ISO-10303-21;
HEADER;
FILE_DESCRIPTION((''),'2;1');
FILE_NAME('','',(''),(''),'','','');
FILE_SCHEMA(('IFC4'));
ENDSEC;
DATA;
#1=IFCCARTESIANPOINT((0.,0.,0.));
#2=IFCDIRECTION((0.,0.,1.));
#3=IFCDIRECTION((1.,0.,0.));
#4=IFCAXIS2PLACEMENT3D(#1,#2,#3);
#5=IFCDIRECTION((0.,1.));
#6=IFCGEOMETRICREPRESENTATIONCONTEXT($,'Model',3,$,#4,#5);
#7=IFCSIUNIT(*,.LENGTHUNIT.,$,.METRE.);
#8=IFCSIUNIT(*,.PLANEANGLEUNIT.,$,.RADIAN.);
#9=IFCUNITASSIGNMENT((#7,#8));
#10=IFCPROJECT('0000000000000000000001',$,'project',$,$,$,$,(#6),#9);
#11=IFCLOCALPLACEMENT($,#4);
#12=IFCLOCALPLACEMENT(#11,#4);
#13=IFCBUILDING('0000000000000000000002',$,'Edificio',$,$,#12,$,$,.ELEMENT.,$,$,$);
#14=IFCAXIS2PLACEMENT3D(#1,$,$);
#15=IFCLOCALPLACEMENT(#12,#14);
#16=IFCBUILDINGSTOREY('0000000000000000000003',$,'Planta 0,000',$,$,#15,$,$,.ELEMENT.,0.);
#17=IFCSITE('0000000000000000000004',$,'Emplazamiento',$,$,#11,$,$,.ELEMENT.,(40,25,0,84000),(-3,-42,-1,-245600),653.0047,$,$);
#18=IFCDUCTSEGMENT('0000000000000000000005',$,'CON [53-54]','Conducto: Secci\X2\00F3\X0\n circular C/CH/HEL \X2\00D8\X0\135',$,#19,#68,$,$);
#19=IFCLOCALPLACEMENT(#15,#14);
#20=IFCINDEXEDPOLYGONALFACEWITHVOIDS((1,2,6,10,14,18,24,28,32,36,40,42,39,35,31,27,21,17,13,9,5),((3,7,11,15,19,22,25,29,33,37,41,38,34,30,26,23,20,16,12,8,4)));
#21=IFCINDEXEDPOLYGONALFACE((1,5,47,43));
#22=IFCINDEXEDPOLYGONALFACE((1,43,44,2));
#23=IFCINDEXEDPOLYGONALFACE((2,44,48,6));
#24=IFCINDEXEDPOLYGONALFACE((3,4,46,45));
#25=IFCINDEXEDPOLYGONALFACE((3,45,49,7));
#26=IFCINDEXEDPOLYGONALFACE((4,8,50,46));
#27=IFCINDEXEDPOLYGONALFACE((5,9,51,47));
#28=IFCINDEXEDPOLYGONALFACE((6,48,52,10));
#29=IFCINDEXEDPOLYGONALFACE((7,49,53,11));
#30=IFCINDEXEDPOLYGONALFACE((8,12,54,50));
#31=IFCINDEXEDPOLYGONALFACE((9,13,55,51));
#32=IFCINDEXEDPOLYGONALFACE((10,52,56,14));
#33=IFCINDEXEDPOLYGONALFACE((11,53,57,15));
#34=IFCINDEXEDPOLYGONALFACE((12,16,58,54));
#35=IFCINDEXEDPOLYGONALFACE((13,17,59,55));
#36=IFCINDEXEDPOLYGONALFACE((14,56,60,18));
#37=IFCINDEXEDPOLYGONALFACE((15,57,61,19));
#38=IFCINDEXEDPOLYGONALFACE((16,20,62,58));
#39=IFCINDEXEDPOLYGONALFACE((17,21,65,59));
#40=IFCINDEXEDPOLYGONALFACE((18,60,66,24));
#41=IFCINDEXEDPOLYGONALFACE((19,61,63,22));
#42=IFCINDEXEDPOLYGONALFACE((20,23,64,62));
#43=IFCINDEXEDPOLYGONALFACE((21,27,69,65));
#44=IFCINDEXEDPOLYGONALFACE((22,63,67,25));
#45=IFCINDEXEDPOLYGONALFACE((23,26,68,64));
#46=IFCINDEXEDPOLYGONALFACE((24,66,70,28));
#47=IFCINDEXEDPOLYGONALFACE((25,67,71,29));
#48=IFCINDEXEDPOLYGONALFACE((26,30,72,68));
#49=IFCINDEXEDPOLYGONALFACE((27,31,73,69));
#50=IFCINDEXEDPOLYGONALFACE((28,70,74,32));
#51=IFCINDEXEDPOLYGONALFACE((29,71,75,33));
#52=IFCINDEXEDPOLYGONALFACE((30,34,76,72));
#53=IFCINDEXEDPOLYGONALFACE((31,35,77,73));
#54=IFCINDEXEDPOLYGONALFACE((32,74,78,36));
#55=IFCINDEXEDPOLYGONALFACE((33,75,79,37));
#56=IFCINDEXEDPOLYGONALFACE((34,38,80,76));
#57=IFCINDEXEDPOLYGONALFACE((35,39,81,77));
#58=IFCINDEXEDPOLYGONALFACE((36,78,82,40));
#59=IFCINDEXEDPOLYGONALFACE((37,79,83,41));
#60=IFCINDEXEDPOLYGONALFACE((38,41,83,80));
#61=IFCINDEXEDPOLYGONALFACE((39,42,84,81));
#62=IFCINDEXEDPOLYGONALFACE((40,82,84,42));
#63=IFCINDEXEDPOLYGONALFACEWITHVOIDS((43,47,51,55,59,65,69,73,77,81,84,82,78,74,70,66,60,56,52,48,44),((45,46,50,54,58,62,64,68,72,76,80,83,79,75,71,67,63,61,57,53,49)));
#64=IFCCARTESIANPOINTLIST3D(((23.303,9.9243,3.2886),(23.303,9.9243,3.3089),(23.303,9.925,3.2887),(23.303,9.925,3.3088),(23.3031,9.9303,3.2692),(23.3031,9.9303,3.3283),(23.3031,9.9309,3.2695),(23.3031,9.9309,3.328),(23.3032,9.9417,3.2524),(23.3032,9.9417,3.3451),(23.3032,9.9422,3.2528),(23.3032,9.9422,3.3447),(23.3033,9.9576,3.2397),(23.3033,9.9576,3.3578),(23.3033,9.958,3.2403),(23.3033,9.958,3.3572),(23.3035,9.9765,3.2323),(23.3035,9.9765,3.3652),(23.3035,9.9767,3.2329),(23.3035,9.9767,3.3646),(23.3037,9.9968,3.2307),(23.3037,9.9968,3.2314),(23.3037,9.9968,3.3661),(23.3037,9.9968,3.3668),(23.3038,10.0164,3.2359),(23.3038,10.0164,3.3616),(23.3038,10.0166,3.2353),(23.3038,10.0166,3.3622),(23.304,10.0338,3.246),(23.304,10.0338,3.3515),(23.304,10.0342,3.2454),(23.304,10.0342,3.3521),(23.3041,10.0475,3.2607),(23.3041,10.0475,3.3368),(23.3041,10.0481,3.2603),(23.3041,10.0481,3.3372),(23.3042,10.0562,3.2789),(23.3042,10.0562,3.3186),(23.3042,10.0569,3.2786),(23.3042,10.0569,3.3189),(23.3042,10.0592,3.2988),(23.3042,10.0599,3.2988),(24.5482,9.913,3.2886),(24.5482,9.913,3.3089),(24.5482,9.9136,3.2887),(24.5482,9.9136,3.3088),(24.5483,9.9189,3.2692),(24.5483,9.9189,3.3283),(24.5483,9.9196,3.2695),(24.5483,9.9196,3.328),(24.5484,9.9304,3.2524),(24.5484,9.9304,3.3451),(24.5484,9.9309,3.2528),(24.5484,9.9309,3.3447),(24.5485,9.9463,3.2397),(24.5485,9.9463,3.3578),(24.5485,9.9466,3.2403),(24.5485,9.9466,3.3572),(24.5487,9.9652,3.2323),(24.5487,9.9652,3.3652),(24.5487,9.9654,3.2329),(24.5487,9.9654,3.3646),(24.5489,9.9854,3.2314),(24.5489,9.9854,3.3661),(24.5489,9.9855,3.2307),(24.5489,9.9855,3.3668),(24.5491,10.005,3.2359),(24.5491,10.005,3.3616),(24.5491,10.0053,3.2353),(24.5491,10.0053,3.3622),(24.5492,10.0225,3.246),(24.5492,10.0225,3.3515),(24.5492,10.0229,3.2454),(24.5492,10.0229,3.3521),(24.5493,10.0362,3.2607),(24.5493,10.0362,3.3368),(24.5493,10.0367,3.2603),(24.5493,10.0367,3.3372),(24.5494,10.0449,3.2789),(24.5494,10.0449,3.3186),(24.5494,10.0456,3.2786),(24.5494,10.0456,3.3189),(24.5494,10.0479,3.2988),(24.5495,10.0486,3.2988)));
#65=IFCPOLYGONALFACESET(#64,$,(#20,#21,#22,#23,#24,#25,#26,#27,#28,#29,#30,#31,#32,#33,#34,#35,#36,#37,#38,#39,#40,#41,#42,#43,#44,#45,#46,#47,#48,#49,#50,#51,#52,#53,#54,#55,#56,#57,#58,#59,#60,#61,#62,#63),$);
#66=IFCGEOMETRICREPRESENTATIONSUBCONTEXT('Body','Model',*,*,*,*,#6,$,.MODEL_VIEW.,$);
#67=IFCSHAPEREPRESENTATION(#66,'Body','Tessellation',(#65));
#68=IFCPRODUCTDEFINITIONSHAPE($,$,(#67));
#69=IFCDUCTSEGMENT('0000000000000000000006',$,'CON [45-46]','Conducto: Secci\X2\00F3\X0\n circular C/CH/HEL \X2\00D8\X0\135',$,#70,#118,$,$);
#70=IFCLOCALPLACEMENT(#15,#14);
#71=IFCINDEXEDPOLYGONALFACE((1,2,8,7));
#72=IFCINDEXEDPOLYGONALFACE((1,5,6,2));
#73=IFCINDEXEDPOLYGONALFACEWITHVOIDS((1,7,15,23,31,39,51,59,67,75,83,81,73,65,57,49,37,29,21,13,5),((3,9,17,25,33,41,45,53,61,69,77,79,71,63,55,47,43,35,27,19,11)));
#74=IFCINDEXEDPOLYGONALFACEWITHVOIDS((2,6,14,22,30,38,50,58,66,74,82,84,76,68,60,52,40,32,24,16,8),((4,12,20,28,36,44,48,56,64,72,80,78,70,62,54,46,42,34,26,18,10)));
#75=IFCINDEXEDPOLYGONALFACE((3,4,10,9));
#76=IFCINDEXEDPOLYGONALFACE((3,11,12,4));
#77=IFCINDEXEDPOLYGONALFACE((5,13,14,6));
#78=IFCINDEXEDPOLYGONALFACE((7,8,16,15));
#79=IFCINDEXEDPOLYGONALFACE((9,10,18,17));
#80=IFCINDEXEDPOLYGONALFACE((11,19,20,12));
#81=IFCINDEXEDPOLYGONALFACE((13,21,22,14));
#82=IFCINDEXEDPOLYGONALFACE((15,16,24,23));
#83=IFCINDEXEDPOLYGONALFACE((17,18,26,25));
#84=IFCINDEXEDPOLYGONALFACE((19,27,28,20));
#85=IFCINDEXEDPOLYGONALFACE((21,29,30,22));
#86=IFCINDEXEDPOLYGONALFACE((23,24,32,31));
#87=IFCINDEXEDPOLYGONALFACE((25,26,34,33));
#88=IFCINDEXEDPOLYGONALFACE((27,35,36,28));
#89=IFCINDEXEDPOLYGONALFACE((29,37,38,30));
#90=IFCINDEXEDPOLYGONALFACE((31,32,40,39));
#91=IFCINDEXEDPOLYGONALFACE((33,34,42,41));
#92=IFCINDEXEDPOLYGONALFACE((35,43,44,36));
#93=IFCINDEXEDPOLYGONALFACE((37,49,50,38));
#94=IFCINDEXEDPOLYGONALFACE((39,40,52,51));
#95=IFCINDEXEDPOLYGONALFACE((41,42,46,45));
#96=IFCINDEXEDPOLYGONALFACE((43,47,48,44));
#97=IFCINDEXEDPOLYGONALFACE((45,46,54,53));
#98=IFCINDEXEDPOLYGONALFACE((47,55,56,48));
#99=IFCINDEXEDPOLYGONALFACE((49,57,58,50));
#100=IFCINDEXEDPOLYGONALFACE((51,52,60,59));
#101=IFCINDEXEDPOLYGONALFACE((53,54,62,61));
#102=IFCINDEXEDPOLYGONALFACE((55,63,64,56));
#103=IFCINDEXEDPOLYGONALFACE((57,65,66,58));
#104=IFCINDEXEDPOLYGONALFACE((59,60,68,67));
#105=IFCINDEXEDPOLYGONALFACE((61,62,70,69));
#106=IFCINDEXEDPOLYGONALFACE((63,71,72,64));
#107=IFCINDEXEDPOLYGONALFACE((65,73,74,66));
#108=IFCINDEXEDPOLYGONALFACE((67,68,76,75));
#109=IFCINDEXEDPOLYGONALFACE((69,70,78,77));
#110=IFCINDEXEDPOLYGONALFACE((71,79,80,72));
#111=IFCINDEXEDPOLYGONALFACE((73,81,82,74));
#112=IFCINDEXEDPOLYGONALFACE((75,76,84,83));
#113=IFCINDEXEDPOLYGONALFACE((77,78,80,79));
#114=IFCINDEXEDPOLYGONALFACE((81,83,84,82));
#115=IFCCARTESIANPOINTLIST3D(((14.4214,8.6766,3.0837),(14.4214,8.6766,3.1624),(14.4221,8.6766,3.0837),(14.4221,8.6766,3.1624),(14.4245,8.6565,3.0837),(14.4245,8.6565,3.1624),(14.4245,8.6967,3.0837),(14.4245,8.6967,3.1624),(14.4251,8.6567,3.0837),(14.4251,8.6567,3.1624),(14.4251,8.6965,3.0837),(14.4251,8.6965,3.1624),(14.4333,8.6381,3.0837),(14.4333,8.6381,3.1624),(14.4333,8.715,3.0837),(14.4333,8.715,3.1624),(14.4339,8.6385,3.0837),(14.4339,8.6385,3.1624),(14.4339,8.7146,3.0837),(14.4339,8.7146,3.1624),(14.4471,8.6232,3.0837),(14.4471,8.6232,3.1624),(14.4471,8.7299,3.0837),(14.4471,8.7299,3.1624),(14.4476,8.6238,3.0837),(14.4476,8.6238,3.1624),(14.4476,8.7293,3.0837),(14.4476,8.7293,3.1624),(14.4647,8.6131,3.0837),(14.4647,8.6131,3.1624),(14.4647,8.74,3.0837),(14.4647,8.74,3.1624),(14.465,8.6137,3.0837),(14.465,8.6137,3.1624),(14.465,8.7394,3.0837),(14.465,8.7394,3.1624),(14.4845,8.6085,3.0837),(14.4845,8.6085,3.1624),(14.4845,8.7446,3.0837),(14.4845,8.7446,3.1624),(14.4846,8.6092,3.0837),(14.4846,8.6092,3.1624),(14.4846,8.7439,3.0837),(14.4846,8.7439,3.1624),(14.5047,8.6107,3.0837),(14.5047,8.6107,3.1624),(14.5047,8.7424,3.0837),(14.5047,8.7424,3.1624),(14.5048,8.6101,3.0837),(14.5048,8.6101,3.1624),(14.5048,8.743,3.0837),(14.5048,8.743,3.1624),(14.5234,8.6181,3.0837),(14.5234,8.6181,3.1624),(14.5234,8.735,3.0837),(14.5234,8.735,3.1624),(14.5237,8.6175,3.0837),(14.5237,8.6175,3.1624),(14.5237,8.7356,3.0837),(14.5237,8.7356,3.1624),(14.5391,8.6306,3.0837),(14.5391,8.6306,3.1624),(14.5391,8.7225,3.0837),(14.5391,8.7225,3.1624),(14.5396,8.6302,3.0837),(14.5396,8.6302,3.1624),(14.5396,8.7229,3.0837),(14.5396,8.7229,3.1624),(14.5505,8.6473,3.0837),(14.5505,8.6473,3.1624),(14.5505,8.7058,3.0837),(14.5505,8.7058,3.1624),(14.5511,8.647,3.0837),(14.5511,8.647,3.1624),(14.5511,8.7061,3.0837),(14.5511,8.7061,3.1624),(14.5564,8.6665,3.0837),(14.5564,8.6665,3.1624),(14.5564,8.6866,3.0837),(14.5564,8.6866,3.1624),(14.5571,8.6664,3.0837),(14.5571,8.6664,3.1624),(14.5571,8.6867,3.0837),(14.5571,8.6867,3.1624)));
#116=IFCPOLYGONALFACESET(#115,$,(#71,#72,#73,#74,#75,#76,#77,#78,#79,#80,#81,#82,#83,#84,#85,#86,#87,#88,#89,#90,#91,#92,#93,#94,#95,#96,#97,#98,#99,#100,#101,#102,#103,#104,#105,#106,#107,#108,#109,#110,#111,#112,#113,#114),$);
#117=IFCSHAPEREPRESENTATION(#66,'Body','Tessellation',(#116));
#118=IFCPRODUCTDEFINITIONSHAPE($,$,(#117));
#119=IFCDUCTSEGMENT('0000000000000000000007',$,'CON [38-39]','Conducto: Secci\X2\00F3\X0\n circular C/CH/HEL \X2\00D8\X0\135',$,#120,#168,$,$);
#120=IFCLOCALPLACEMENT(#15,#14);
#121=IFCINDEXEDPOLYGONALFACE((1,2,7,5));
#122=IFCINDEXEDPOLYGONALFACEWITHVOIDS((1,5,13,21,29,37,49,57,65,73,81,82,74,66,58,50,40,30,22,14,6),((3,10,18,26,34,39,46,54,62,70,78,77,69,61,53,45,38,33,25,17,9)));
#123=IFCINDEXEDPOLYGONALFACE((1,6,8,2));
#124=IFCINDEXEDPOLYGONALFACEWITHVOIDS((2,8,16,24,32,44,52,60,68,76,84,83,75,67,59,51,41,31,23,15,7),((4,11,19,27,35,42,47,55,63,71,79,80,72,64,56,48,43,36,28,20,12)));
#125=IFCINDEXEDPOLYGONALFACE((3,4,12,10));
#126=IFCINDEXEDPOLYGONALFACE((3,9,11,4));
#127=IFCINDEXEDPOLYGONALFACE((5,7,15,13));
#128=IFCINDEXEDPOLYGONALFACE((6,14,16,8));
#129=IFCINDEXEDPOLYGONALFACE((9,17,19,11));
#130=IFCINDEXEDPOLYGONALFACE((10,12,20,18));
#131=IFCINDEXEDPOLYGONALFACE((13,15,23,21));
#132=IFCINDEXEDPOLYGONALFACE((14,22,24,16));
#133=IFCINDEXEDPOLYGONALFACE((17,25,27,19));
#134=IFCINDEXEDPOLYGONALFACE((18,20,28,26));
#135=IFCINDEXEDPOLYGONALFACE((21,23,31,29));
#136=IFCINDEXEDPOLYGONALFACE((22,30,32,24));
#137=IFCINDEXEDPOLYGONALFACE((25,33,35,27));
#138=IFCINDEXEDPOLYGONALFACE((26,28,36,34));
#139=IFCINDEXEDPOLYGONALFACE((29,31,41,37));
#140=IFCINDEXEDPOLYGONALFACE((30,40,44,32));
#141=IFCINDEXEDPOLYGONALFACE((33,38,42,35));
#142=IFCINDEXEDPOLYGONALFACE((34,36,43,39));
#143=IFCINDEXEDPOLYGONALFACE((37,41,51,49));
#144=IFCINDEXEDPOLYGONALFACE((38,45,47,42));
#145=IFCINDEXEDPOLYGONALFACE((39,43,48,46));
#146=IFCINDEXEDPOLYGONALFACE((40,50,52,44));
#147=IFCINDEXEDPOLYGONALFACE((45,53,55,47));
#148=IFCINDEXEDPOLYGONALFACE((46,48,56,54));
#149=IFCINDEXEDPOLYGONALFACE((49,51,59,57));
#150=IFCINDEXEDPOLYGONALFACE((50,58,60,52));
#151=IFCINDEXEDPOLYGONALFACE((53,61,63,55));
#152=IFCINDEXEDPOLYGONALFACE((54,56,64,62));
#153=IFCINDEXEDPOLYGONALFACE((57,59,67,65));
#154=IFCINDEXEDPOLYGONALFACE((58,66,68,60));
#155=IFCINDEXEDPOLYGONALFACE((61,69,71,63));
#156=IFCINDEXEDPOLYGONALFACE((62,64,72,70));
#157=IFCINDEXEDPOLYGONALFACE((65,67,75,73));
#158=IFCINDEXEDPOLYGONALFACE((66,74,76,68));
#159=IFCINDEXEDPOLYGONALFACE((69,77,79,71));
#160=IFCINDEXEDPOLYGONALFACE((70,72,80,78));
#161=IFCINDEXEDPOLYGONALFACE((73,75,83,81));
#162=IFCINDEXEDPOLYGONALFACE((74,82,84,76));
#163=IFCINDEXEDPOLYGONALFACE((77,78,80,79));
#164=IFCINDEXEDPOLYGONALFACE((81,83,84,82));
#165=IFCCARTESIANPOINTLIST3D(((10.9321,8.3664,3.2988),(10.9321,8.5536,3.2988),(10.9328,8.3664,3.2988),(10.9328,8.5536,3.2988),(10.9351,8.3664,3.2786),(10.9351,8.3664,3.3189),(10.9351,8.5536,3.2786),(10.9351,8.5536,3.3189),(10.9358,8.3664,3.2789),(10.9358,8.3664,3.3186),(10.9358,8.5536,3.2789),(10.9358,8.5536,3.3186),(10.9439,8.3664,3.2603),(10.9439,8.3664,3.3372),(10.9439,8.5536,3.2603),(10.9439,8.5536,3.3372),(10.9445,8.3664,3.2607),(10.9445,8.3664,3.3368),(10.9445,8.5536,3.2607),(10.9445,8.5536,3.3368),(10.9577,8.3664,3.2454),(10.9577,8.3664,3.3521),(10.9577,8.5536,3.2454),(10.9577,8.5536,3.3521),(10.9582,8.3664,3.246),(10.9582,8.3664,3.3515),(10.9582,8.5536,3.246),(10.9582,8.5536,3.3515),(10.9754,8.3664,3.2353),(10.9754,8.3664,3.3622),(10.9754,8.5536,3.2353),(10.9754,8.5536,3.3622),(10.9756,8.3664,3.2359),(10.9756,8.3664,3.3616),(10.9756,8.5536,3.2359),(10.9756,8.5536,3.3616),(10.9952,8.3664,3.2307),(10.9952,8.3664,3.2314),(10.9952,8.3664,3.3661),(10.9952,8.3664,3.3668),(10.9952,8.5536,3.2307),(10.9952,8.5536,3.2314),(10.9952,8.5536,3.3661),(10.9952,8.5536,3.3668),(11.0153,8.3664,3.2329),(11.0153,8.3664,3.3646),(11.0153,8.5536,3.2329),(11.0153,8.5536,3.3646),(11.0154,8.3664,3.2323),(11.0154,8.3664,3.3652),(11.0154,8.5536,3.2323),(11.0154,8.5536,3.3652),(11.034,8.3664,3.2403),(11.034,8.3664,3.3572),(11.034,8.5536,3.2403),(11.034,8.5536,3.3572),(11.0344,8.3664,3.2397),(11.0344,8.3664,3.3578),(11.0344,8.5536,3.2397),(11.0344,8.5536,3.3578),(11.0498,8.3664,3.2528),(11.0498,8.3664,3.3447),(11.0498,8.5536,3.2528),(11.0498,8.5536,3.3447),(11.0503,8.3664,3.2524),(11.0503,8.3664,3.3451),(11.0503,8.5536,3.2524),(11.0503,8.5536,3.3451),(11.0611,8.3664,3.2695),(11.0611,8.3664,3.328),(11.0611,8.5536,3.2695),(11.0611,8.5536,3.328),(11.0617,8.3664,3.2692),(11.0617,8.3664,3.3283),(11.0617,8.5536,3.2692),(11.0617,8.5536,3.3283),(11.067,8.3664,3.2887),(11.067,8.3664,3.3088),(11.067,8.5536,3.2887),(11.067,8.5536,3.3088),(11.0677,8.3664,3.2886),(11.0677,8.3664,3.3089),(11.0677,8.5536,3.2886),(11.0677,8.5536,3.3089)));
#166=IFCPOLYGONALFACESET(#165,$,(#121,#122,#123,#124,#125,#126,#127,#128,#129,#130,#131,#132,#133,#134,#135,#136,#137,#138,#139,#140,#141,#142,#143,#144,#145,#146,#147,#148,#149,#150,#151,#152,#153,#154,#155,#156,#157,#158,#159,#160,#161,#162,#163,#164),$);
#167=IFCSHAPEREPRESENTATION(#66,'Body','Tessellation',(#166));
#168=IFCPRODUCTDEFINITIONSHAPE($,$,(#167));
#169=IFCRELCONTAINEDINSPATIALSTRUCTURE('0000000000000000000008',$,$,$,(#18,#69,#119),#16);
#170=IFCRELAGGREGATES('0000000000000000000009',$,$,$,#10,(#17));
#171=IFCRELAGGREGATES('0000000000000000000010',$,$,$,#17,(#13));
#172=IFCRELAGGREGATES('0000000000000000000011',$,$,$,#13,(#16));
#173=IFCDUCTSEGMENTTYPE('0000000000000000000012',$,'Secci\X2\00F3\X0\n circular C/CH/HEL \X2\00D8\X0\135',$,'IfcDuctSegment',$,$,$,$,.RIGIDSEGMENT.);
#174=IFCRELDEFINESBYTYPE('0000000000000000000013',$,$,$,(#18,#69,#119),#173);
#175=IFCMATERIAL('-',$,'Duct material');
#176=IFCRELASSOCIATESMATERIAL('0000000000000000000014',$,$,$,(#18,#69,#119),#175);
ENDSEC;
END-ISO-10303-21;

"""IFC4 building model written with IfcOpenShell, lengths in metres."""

from ifc_helpers import new_model, si_unit, direction, frame, origin, origin_with_axes, origin_2d_with_axis, place, context, subcontext, project, spatial, hollow_circle, extrude, material, type_object, element, save


model = new_model("IFC4")

# Units and contexts
model_context = context("Model", 3, world=origin_with_axes(), true_north=direction((0.0, 1.0)))
body_context = subcontext(model_context, "Body", "Model", "MODEL_VIEW")
ifc_project = project(units=[si_unit("LENGTHUNIT", "METRE"), si_unit("PLANEANGLEUNIT", "RADIAN")], contexts=[model_context])

# Site, building, storey
site_placement = place(None, origin_with_axes())
site = spatial("IfcSite", under=ifc_project, at=site_placement, Name="Emplazamiento", CompositionType="ELEMENT", RefLatitude=(40, 25, 0, 84000), RefLongitude=(-3, -42, -1, -245600), RefElevation=653.0047)
building_placement = place(site_placement, origin_with_axes())
building = spatial("IfcBuilding", under=site, at=building_placement, Name="Edificio", CompositionType="ELEMENT")
storey_placement = place(building_placement, origin())
storey = spatial("IfcBuildingStorey", under=building, at=storey_placement, Name="Planta 0,000", CompositionType="ELEMENT", Elevation=0.0)

# Shared definitions
ifc_material_1 = material(Name="-", Category="Duct material")

# Duct segments
duct_segment_type_1 = type_object("IfcDuctSegmentType", Name="Sección circular C/CH/HEL Ø135", ApplicableOccurrence="IfcDuctSegment", PredefinedType="RIGIDSEGMENT")
duct_segment_1_placement = place(storey_placement, origin_with_axes())
element("IfcDuctSegment", 1, at=duct_segment_1_placement, inside=storey, type_object=duct_segment_type_1, material=ifc_material_1, Name="CON [53-54]", Description="Conducto: Sección circular C/CH/HEL Ø135", context=body_context, shape_type="SweptSolid", body=[
    extrude(hollow_circle(Radius=0.0682, WallThickness=0.0007, at=origin_2d_with_axis()), frame((23.3036, 9.9917, 3.2988), z_axis=(0.999959, -0.009091, 0.0), x_axis=(0.009091, 0.999959, 0.0)), (0.0, 0.0, 1.0), 1.2453),
])
duct_segment_2_placement = place(storey_placement, origin_with_axes())
element("IfcDuctSegment", 2, at=duct_segment_2_placement, inside=storey, type_object=duct_segment_type_1, material=ifc_material_1, Name="CON [45-46]", Description="Conducto: Sección circular C/CH/HEL Ø135", context=body_context, shape_type="SweptSolid", body=[
    extrude(hollow_circle(Radius=0.0682, WallThickness=0.0007, at=origin_2d_with_axis()), frame((14.4896, 8.6766, 3.1624), z_axis=(0.0, 0.0, -1.0), x_axis=(-1.0, 0.0, 0.0)), (0.0, 0.0, 1.0), 0.0786),
])
duct_segment_3_placement = place(storey_placement, origin_with_axes())
element("IfcDuctSegment", 3, at=duct_segment_3_placement, inside=storey, type_object=duct_segment_type_1, material=ifc_material_1, Name="CON [38-39]", Description="Conducto: Sección circular C/CH/HEL Ø135", context=body_context, shape_type="SweptSolid", body=[
    extrude(hollow_circle(Radius=0.0682, WallThickness=0.0007, at=origin_2d_with_axis()), frame((11.0003, 8.3664, 3.2988), z_axis=(0.0, 1.0, 0.0), x_axis=(-1.0, 0.0, 0.0)), (0.0, 0.0, 1.0), 0.1872),
])

save(model, "model.ifc")
